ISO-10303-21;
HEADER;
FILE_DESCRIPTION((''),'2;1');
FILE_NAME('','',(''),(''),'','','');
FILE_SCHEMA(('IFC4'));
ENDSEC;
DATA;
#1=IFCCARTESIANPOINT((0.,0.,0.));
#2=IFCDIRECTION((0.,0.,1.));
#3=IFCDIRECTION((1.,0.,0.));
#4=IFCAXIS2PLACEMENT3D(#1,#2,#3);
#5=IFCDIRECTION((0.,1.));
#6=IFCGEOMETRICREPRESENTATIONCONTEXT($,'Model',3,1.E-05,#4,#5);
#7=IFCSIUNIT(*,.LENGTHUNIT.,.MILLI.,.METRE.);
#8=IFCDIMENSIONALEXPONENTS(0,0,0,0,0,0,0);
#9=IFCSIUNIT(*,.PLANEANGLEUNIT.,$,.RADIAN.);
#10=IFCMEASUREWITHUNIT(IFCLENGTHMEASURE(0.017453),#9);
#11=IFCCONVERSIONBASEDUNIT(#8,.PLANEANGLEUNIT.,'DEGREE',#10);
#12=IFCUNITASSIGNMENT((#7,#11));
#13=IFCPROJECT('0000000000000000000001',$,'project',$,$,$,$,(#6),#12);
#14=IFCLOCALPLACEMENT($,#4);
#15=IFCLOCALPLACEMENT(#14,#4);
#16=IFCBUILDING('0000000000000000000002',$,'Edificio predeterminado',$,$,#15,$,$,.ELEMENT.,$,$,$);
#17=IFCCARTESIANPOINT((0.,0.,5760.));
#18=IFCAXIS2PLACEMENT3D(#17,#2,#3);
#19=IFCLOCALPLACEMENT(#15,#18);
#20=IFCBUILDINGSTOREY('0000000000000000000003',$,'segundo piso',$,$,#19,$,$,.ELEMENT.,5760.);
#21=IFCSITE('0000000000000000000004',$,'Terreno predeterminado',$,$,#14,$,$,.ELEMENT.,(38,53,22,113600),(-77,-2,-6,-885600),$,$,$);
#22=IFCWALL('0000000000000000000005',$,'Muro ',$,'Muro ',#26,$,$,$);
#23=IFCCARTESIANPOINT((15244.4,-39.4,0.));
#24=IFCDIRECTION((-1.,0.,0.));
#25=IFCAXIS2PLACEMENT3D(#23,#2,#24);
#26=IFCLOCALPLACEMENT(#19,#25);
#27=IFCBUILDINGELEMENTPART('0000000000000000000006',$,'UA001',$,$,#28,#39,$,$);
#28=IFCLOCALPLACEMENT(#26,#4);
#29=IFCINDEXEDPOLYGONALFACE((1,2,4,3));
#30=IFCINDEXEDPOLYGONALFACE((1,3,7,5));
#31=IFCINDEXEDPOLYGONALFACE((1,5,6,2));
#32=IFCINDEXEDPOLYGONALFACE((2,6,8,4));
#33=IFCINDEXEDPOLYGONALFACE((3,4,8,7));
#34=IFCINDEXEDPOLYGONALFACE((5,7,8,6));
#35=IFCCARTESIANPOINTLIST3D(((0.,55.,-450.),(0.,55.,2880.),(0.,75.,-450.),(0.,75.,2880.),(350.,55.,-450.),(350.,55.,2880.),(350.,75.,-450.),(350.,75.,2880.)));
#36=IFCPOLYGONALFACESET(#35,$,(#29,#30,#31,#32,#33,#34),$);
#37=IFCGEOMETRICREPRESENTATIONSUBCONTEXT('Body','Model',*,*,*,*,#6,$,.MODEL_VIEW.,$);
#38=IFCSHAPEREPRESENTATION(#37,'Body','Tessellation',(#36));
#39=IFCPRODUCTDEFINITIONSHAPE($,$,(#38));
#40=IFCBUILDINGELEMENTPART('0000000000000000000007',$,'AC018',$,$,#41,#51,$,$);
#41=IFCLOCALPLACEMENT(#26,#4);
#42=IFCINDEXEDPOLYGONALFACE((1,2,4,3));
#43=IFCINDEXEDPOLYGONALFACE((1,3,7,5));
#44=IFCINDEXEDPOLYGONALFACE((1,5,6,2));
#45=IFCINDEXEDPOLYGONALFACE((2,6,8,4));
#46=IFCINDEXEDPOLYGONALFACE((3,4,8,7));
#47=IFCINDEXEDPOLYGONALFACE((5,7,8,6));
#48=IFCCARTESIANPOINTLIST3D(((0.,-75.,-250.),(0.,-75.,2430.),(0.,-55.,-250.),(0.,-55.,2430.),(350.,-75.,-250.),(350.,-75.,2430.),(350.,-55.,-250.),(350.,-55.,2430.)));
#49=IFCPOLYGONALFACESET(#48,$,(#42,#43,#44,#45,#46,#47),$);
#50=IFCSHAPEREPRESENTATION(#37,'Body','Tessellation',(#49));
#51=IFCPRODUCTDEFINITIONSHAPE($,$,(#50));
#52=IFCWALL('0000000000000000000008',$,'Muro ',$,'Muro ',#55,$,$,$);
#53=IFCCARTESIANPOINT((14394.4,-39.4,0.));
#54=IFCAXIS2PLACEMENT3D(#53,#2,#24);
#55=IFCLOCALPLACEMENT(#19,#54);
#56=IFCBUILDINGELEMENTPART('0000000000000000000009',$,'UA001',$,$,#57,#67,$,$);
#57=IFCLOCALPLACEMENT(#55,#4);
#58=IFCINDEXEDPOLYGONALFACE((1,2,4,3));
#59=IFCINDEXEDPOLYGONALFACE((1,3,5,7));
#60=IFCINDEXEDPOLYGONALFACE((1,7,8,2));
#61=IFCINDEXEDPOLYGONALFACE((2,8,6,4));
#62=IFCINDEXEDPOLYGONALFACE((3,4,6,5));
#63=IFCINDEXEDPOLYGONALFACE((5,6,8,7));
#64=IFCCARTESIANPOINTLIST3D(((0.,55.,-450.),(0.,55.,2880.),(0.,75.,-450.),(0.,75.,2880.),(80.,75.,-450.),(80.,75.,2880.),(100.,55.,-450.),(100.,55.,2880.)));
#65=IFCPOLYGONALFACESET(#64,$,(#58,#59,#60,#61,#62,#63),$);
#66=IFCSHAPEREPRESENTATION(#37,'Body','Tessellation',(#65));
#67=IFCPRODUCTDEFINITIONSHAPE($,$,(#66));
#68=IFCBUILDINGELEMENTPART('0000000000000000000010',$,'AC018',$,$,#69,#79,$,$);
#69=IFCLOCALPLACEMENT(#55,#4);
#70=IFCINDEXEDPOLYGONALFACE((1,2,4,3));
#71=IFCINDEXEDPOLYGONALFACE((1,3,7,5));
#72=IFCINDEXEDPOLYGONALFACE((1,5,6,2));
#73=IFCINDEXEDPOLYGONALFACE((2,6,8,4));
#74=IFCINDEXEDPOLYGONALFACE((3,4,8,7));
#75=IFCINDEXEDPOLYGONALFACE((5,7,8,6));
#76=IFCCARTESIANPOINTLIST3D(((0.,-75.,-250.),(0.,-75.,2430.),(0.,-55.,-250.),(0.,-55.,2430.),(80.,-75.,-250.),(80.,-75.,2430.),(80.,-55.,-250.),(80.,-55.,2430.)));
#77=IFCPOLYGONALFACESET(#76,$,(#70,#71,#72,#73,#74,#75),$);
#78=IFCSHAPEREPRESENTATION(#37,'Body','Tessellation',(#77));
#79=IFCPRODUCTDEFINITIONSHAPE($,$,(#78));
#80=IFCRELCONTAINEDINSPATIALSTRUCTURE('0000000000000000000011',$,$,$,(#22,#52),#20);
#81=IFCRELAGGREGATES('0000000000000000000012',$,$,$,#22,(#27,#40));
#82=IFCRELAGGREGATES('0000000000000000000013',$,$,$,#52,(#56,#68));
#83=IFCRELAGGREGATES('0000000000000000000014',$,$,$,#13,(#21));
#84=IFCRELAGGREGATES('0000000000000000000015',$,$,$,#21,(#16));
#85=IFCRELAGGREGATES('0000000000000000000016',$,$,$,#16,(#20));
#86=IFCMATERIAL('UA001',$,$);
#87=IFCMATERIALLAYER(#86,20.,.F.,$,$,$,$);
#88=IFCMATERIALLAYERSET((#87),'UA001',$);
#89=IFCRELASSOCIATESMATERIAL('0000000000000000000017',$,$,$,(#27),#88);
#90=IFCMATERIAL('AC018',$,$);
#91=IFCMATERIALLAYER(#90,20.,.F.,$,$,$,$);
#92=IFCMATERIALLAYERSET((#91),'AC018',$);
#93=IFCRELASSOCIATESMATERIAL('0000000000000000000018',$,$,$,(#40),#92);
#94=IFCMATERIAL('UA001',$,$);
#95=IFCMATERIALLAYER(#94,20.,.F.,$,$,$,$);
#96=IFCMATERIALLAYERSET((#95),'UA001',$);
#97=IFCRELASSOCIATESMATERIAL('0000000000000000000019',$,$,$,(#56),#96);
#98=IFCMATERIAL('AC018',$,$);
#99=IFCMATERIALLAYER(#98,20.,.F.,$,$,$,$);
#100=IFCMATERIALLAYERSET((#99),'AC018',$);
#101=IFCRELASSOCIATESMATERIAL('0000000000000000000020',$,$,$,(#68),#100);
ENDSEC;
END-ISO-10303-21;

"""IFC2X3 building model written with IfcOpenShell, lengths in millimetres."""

from ifc_helpers import new_model, entity, si_unit, converted_unit, direction, frame, origin_with_axes, place, context, subcontext, project, spatial, polyline, outline, extrude, material, layer, layer_set, layer_usage, element, aggregate, save


model = new_model("IFC2X3")

# Units and contexts
model_context = context("Model", 3, precision=1e-05, world=origin_with_axes(), true_north=direction((0.0, 1.0)))
body_context = subcontext(model_context, "Body", "Model", "MODEL_VIEW")
ifc_project = project(units=[si_unit("LENGTHUNIT", "METRE", prefix="MILLI"), converted_unit("PLANEANGLEUNIT", "DEGREE", entity("IfcLengthMeasure", 0.017453), si_unit("PLANEANGLEUNIT", "RADIAN"), dimensions=[0, 0, 0, 0, 0, 0, 0])], contexts=[model_context])

# Site, building, storey
site_placement = place(None, origin_with_axes())
site = spatial("IfcSite", under=ifc_project, at=site_placement, Name="Terreno predeterminado", CompositionType="ELEMENT", RefLatitude=(38, 53, 22, 113600), RefLongitude=(-77, -2, -6, -885600))
building_placement = place(site_placement, origin_with_axes())
building = spatial("IfcBuilding", under=site, at=building_placement, Name="Edificio predeterminado", CompositionType="ELEMENT")
storey_placement = place(building_placement, frame((0.0, 0.0, 5760.0), z_axis=(0.0, 0.0, 1.0), x_axis=(1.0, 0.0, 0.0)))
storey = spatial("IfcBuildingStorey", under=building, at=storey_placement, Name="segundo piso", CompositionType="ELEMENT", Elevation=5760.0)

# Walls, building element parts
wall_1_placement = place(storey_placement, frame((15244.4, -39.4, 0.0), z_axis=(0.0, 0.0, 1.0), x_axis=(-1.0, 0.0, 0.0)))
wall_1 = element("IfcWall", 1, at=wall_1_placement, inside=storey, Name="Muro ", ObjectType="Muro ")
ifc_material_1 = material(Name="UA001")
ifc_layer_1 = layer(ifc_material_1, 20.0, ventilated=False)
ifc_layer_set_1 = layer_set([ifc_layer_1], Name="UA001")
ifc_layer_usage_1 = layer_usage(ifc_layer_set_1, "AXIS2", "NEGATIVE", -75.0)
building_element_part_1_placement = place(wall_1_placement, origin_with_axes())
building_element_part_1 = element("IfcBuildingElementPart", 2, at=building_element_part_1_placement, material=ifc_layer_usage_1, Name="UA001", context=body_context, shape_type="SweptSolid", body=[
    extrude(outline(polyline([(350.0, 75.0), (350.0, 55.0), (0.0, 55.0), (0.0, 75.0), (350.0, 75.0)])), frame((0.0, 0.0, -450.0), z_axis=(0.0, 0.0, 1.0), x_axis=(1.0, 0.0, 0.0)), (0.0, 0.0, 1.0), 3330.0),
])
ifc_material_2 = material(Name="AC018")
ifc_layer_2 = layer(ifc_material_2, 20.0, ventilated=False)
ifc_layer_set_2 = layer_set([ifc_layer_2], Name="AC018")
ifc_layer_usage_2 = layer_usage(ifc_layer_set_2, "AXIS2", "NEGATIVE", 55.0)
building_element_part_2_placement = place(wall_1_placement, origin_with_axes())
building_element_part_2 = element("IfcBuildingElementPart", 3, at=building_element_part_2_placement, material=ifc_layer_usage_2, Name="AC018", context=body_context, shape_type="SweptSolid", body=[
    extrude(outline(polyline([(350.0, -55.0), (350.0, -75.0), (0.0, -75.0), (0.0, -55.0), (350.0, -55.0)])), frame((0.0, 0.0, -250.0), z_axis=(0.0, 0.0, 1.0), x_axis=(1.0, 0.0, 0.0)), (0.0, 0.0, 1.0), 2680.0),
])
aggregate(wall_1, [building_element_part_1, building_element_part_2])
wall_2_placement = place(storey_placement, frame((14394.4, -39.4, 0.0), z_axis=(0.0, 0.0, 1.0), x_axis=(-1.0, 0.0, 0.0)))
wall_2 = element("IfcWall", 4, at=wall_2_placement, inside=storey, Name="Muro ", ObjectType="Muro ")
ifc_material_3 = material(Name="UA001")
ifc_layer_3 = layer(ifc_material_3, 20.0, ventilated=False)
ifc_layer_set_3 = layer_set([ifc_layer_3], Name="UA001")
ifc_layer_usage_3 = layer_usage(ifc_layer_set_3, "AXIS2", "NEGATIVE", -75.0)
building_element_part_3_placement = place(wall_2_placement, origin_with_axes())
building_element_part_3 = element("IfcBuildingElementPart", 5, at=building_element_part_3_placement, material=ifc_layer_usage_3, Name="UA001", context=body_context, shape_type="SweptSolid", body=[
    extrude(outline(polyline([(80.0, 75.0), (100.0, 55.0), (0.0, 55.0), (0.0, 75.0), (80.0, 75.0)])), frame((0.0, 0.0, -450.0), z_axis=(0.0, 0.0, 1.0), x_axis=(1.0, 0.0, 0.0)), (0.0, 0.0, 1.0), 3330.0),
])
ifc_material_4 = material(Name="AC018")
ifc_layer_4 = layer(ifc_material_4, 20.0, ventilated=False)
ifc_layer_set_4 = layer_set([ifc_layer_4], Name="AC018")
ifc_layer_usage_4 = layer_usage(ifc_layer_set_4, "AXIS2", "NEGATIVE", 55.0)
building_element_part_4_placement = place(wall_2_placement, origin_with_axes())
building_element_part_4 = element("IfcBuildingElementPart", 6, at=building_element_part_4_placement, material=ifc_layer_usage_4, Name="AC018", context=body_context, shape_type="SweptSolid", body=[
    extrude(outline(polyline([(80.0, -55.0), (80.0, -75.0), (0.0, -75.0), (0.0, -55.0), (80.0, -55.0)])), frame((0.0, 0.0, -250.0), z_axis=(0.0, 0.0, 1.0), x_axis=(1.0, 0.0, 0.0)), (0.0, 0.0, 1.0), 2680.0),
])
aggregate(wall_2, [building_element_part_3, building_element_part_4])

save(model, "model.ifc")
